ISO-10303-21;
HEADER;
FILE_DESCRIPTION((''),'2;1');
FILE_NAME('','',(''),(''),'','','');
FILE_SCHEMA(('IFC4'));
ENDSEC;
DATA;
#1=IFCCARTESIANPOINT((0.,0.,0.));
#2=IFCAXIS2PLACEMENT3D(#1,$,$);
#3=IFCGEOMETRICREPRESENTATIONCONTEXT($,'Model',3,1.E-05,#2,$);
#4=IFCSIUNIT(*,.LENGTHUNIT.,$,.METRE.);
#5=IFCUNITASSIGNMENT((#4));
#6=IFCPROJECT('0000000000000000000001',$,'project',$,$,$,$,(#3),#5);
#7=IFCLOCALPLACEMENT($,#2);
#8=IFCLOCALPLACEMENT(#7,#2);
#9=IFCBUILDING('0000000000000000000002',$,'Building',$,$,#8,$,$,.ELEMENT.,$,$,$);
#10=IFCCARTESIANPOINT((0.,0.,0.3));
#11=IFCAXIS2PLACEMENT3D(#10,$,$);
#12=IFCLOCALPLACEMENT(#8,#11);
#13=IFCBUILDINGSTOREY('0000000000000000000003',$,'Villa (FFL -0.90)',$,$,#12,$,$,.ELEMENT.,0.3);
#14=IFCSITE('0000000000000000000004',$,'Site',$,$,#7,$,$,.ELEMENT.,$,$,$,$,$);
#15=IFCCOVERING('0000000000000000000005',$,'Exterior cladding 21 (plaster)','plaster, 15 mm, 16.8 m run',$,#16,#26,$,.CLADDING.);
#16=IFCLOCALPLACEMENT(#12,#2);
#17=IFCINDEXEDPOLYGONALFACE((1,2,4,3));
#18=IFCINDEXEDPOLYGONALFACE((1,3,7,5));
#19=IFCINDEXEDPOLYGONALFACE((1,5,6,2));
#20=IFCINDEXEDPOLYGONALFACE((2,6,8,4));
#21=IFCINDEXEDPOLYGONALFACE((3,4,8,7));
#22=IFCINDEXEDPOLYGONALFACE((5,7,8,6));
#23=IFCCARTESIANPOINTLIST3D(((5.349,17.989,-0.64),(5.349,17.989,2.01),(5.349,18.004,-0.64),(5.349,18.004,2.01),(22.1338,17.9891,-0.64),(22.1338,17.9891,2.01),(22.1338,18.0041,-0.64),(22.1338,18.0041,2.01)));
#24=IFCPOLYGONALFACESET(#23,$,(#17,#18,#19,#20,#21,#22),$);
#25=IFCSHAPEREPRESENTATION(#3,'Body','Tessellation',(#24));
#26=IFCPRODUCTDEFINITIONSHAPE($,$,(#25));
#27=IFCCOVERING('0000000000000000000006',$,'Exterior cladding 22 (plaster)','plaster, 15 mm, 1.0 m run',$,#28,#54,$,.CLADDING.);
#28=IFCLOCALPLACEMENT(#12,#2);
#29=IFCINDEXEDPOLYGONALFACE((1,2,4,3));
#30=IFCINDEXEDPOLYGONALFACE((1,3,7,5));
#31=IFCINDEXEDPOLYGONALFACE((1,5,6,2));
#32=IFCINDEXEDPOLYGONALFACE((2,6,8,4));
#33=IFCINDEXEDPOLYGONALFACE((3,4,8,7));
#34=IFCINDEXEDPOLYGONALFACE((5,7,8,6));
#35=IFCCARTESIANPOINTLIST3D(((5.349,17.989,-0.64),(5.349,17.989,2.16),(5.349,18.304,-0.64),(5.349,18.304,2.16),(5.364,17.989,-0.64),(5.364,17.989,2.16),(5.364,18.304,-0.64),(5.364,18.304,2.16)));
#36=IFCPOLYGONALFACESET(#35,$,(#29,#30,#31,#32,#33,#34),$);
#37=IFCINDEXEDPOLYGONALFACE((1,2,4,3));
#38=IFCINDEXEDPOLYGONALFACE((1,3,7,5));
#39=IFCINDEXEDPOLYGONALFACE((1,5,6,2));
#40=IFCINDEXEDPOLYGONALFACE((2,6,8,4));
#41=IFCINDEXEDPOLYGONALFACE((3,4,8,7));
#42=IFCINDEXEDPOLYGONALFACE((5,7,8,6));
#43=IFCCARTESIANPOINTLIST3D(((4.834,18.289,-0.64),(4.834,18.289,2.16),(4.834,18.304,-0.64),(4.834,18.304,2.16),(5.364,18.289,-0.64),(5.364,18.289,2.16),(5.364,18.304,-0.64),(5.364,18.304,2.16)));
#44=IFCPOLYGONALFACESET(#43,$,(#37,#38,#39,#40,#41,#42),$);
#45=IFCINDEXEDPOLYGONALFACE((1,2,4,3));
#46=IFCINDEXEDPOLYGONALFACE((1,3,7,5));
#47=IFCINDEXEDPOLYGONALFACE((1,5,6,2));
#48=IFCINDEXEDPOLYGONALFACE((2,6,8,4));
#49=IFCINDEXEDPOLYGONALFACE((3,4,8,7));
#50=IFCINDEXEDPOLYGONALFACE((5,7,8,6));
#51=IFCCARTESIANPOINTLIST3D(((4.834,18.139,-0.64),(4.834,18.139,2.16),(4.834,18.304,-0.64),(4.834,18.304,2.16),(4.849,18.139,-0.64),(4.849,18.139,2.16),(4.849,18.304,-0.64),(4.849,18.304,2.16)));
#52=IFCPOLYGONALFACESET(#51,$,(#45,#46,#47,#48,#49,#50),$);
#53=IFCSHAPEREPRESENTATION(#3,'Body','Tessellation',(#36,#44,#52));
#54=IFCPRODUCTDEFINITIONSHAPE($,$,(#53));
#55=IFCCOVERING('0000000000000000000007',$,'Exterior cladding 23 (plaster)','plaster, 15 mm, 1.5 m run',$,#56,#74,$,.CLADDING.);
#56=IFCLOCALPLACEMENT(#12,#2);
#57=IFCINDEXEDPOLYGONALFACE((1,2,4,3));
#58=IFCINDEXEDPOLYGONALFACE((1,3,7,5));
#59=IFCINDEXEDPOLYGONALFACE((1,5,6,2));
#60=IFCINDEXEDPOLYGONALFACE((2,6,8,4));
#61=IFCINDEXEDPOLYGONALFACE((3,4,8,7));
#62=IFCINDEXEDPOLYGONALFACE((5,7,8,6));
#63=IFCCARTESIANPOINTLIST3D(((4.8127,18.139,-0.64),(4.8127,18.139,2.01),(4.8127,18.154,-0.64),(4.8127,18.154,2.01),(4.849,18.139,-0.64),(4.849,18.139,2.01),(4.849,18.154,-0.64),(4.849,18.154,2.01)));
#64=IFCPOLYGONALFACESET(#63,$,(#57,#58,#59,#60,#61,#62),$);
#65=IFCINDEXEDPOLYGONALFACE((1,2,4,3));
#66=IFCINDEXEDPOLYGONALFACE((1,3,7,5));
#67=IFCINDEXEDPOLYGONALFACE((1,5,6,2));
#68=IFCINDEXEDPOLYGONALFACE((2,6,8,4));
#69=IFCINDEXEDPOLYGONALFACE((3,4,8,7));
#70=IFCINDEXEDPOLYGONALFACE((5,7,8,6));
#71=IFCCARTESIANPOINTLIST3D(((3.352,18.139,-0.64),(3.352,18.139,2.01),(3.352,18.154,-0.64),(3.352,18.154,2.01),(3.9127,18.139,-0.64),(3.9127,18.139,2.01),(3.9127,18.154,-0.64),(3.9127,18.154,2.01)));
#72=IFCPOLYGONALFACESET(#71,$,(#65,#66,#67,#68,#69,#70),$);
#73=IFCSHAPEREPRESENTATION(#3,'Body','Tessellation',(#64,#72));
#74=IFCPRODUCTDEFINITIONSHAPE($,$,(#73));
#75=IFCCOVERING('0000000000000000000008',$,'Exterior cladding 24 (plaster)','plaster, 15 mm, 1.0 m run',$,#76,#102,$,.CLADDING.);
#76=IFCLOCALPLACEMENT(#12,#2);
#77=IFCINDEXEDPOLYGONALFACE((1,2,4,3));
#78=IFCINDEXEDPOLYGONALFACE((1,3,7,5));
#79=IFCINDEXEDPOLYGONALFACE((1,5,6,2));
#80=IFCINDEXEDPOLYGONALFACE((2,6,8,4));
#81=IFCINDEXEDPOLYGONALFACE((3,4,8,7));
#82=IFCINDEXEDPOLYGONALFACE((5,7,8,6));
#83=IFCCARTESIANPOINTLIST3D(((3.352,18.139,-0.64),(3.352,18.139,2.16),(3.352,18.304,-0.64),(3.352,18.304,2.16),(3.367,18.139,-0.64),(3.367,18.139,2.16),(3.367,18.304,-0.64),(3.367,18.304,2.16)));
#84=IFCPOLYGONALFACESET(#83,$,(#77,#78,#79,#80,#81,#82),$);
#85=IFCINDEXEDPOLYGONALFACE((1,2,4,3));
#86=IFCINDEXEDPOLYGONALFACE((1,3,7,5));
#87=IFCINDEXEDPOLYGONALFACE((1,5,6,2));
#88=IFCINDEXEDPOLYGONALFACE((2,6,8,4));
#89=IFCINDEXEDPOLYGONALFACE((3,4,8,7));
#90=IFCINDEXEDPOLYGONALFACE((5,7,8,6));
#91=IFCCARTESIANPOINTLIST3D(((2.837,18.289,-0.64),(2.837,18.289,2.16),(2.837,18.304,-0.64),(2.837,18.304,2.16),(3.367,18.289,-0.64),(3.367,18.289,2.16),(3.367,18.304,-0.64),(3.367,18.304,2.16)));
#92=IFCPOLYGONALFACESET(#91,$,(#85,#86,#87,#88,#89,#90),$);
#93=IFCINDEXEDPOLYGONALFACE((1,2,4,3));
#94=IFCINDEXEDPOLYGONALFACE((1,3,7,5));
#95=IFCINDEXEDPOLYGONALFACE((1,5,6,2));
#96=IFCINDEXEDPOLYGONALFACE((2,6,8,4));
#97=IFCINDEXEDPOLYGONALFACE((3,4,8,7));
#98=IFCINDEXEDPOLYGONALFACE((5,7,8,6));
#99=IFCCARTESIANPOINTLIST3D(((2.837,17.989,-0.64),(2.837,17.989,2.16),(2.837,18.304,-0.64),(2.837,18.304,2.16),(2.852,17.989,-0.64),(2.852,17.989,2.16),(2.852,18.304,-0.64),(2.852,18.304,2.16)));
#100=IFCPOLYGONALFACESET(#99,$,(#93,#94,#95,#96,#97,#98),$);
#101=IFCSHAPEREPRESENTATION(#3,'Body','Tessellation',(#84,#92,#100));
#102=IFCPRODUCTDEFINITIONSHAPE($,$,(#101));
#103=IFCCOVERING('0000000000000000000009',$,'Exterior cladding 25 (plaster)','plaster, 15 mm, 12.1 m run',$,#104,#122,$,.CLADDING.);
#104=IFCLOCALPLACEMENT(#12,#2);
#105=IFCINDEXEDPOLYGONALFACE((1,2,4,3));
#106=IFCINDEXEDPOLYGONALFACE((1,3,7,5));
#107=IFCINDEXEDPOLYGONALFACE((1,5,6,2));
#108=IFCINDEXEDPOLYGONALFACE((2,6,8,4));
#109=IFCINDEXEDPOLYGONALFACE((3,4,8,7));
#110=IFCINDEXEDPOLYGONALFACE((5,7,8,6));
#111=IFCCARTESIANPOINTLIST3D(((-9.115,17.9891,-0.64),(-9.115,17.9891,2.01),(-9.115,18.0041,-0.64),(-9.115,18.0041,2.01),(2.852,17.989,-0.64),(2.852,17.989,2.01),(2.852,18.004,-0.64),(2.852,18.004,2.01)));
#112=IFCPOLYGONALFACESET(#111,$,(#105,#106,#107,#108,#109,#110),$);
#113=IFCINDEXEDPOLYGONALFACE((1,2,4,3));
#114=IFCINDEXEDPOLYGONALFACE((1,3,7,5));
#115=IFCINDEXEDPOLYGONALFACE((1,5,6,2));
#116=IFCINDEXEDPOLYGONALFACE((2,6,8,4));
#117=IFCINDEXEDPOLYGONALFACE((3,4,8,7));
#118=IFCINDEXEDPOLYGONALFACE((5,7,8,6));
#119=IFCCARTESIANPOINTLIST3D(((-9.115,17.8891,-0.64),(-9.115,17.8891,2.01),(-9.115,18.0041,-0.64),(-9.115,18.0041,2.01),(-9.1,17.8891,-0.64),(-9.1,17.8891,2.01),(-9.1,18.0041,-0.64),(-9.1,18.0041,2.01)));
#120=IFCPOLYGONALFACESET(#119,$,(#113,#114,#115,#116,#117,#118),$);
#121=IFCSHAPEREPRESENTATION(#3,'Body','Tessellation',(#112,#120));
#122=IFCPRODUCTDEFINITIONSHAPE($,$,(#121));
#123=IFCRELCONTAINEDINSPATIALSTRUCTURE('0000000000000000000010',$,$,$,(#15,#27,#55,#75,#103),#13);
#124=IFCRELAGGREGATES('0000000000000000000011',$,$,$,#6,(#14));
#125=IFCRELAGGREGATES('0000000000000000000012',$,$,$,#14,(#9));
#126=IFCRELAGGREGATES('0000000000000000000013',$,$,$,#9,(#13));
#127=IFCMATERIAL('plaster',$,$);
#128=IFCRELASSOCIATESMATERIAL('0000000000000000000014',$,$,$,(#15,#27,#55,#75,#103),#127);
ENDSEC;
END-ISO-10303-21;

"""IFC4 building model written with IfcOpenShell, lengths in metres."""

from ifc_helpers import new_model, si_unit, frame, origin, origin_with_axes, place, context, project, spatial, polyline, outline, extrude, material, element, save


model = new_model("IFC4")

# Units and contexts
model_context = context("Model", 3, precision=1e-05, world=origin())
ifc_project = project(units=[si_unit("LENGTHUNIT", "METRE")], contexts=[model_context])

# Site, building, storey
site_placement = place(None, origin())
site = spatial("IfcSite", under=ifc_project, at=site_placement, Name="Site", CompositionType="ELEMENT")
building_placement = place(site_placement, origin())
building = spatial("IfcBuilding", under=site, at=building_placement, Name="Building", CompositionType="ELEMENT")
storey_placement = place(building_placement, frame((0.0, 0.0, 0.3)))
storey = spatial("IfcBuildingStorey", under=building, at=storey_placement, Name="Villa (FFL -0.90)", CompositionType="ELEMENT", Elevation=0.3)

# Coverings
ifc_material = material(Name="plaster")
covering_1_placement = place(storey_placement, origin_with_axes())
element("IfcCovering", 1, at=covering_1_placement, inside=storey, material=ifc_material, Name="Exterior cladding 21 (plaster)", Description="plaster, 15 mm, 16.8 m run", PredefinedType="CLADDING", context=model_context, shape_type="SweptSolid", body=[
    extrude(outline(polyline([(22.1338, 18.0041), (5.349, 18.004), (5.349, 17.989), (22.1338, 17.9891), (22.1338, 18.0041)])), frame((0.0, 0.0, -0.64)), (0.0, 0.0, 1.0), 2.65),
])
covering_2_placement = place(storey_placement, origin_with_axes())
element("IfcCovering", 2, at=covering_2_placement, inside=storey, material=ifc_material, Name="Exterior cladding 22 (plaster)", Description="plaster, 15 mm, 1.0 m run", PredefinedType="CLADDING", context=model_context, shape_type="SweptSolid", body=[
    extrude(outline(polyline([(5.364, 17.989), (5.364, 18.304), (5.349, 18.304), (5.349, 17.989), (5.364, 17.989)])), frame((0.0, 0.0, -0.64)), (0.0, 0.0, 1.0), 2.8),
    extrude(outline(polyline([(5.364, 18.304), (4.834, 18.304), (4.834, 18.289), (5.364, 18.289), (5.364, 18.304)])), frame((0.0, 0.0, -0.64)), (0.0, 0.0, 1.0), 2.8),
    extrude(outline(polyline([(4.834, 18.304), (4.834, 18.139), (4.849, 18.139), (4.849, 18.304), (4.834, 18.304)])), frame((0.0, 0.0, -0.64)), (0.0, 0.0, 1.0), 2.8),
])
covering_3_placement = place(storey_placement, origin_with_axes())
element("IfcCovering", 3, at=covering_3_placement, inside=storey, material=ifc_material, Name="Exterior cladding 23 (plaster)", Description="plaster, 15 mm, 1.5 m run", PredefinedType="CLADDING", context=model_context, shape_type="SweptSolid", body=[
    extrude(outline(polyline([(4.849, 18.154), (4.8127, 18.154), (4.8127, 18.139), (4.849, 18.139), (4.849, 18.154)])), frame((0.0, 0.0, -0.64)), (0.0, 0.0, 1.0), 2.65),
    extrude(outline(polyline([(3.9127, 18.154), (3.352, 18.154), (3.352, 18.139), (3.9127, 18.139), (3.9127, 18.154)])), frame((0.0, 0.0, -0.64)), (0.0, 0.0, 1.0), 2.65),
])
covering_4_placement = place(storey_placement, origin_with_axes())
element("IfcCovering", 4, at=covering_4_placement, inside=storey, material=ifc_material, Name="Exterior cladding 24 (plaster)", Description="plaster, 15 mm, 1.0 m run", PredefinedType="CLADDING", context=model_context, shape_type="SweptSolid", body=[
    extrude(outline(polyline([(3.367, 18.139), (3.367, 18.304), (3.352, 18.304), (3.352, 18.139), (3.367, 18.139)])), frame((0.0, 0.0, -0.64)), (0.0, 0.0, 1.0), 2.8),
    extrude(outline(polyline([(3.367, 18.304), (2.837, 18.304), (2.837, 18.289), (3.367, 18.289), (3.367, 18.304)])), frame((0.0, 0.0, -0.64)), (0.0, 0.0, 1.0), 2.8),
    extrude(outline(polyline([(2.837, 18.304), (2.837, 17.989), (2.852, 17.989), (2.852, 18.304), (2.837, 18.304)])), frame((0.0, 0.0, -0.64)), (0.0, 0.0, 1.0), 2.8),
])
covering_5_placement = place(storey_placement, origin_with_axes())
element("IfcCovering", 5, at=covering_5_placement, inside=storey, material=ifc_material, Name="Exterior cladding 25 (plaster)", Description="plaster, 15 mm, 12.1 m run", PredefinedType="CLADDING", context=model_context, shape_type="SweptSolid", body=[
    extrude(outline(polyline([(2.852, 18.004), (-9.115, 18.0041), (-9.115, 17.9891), (2.852, 17.989), (2.852, 18.004)])), frame((0.0, 0.0, -0.64)), (0.0, 0.0, 1.0), 2.65),
    extrude(outline(polyline([(-9.115, 18.0041), (-9.115, 17.8891), (-9.1, 17.8891), (-9.1, 18.0041), (-9.115, 18.0041)])), frame((0.0, 0.0, -0.64)), (0.0, 0.0, 1.0), 2.65),
])

save(model, "model.ifc")
